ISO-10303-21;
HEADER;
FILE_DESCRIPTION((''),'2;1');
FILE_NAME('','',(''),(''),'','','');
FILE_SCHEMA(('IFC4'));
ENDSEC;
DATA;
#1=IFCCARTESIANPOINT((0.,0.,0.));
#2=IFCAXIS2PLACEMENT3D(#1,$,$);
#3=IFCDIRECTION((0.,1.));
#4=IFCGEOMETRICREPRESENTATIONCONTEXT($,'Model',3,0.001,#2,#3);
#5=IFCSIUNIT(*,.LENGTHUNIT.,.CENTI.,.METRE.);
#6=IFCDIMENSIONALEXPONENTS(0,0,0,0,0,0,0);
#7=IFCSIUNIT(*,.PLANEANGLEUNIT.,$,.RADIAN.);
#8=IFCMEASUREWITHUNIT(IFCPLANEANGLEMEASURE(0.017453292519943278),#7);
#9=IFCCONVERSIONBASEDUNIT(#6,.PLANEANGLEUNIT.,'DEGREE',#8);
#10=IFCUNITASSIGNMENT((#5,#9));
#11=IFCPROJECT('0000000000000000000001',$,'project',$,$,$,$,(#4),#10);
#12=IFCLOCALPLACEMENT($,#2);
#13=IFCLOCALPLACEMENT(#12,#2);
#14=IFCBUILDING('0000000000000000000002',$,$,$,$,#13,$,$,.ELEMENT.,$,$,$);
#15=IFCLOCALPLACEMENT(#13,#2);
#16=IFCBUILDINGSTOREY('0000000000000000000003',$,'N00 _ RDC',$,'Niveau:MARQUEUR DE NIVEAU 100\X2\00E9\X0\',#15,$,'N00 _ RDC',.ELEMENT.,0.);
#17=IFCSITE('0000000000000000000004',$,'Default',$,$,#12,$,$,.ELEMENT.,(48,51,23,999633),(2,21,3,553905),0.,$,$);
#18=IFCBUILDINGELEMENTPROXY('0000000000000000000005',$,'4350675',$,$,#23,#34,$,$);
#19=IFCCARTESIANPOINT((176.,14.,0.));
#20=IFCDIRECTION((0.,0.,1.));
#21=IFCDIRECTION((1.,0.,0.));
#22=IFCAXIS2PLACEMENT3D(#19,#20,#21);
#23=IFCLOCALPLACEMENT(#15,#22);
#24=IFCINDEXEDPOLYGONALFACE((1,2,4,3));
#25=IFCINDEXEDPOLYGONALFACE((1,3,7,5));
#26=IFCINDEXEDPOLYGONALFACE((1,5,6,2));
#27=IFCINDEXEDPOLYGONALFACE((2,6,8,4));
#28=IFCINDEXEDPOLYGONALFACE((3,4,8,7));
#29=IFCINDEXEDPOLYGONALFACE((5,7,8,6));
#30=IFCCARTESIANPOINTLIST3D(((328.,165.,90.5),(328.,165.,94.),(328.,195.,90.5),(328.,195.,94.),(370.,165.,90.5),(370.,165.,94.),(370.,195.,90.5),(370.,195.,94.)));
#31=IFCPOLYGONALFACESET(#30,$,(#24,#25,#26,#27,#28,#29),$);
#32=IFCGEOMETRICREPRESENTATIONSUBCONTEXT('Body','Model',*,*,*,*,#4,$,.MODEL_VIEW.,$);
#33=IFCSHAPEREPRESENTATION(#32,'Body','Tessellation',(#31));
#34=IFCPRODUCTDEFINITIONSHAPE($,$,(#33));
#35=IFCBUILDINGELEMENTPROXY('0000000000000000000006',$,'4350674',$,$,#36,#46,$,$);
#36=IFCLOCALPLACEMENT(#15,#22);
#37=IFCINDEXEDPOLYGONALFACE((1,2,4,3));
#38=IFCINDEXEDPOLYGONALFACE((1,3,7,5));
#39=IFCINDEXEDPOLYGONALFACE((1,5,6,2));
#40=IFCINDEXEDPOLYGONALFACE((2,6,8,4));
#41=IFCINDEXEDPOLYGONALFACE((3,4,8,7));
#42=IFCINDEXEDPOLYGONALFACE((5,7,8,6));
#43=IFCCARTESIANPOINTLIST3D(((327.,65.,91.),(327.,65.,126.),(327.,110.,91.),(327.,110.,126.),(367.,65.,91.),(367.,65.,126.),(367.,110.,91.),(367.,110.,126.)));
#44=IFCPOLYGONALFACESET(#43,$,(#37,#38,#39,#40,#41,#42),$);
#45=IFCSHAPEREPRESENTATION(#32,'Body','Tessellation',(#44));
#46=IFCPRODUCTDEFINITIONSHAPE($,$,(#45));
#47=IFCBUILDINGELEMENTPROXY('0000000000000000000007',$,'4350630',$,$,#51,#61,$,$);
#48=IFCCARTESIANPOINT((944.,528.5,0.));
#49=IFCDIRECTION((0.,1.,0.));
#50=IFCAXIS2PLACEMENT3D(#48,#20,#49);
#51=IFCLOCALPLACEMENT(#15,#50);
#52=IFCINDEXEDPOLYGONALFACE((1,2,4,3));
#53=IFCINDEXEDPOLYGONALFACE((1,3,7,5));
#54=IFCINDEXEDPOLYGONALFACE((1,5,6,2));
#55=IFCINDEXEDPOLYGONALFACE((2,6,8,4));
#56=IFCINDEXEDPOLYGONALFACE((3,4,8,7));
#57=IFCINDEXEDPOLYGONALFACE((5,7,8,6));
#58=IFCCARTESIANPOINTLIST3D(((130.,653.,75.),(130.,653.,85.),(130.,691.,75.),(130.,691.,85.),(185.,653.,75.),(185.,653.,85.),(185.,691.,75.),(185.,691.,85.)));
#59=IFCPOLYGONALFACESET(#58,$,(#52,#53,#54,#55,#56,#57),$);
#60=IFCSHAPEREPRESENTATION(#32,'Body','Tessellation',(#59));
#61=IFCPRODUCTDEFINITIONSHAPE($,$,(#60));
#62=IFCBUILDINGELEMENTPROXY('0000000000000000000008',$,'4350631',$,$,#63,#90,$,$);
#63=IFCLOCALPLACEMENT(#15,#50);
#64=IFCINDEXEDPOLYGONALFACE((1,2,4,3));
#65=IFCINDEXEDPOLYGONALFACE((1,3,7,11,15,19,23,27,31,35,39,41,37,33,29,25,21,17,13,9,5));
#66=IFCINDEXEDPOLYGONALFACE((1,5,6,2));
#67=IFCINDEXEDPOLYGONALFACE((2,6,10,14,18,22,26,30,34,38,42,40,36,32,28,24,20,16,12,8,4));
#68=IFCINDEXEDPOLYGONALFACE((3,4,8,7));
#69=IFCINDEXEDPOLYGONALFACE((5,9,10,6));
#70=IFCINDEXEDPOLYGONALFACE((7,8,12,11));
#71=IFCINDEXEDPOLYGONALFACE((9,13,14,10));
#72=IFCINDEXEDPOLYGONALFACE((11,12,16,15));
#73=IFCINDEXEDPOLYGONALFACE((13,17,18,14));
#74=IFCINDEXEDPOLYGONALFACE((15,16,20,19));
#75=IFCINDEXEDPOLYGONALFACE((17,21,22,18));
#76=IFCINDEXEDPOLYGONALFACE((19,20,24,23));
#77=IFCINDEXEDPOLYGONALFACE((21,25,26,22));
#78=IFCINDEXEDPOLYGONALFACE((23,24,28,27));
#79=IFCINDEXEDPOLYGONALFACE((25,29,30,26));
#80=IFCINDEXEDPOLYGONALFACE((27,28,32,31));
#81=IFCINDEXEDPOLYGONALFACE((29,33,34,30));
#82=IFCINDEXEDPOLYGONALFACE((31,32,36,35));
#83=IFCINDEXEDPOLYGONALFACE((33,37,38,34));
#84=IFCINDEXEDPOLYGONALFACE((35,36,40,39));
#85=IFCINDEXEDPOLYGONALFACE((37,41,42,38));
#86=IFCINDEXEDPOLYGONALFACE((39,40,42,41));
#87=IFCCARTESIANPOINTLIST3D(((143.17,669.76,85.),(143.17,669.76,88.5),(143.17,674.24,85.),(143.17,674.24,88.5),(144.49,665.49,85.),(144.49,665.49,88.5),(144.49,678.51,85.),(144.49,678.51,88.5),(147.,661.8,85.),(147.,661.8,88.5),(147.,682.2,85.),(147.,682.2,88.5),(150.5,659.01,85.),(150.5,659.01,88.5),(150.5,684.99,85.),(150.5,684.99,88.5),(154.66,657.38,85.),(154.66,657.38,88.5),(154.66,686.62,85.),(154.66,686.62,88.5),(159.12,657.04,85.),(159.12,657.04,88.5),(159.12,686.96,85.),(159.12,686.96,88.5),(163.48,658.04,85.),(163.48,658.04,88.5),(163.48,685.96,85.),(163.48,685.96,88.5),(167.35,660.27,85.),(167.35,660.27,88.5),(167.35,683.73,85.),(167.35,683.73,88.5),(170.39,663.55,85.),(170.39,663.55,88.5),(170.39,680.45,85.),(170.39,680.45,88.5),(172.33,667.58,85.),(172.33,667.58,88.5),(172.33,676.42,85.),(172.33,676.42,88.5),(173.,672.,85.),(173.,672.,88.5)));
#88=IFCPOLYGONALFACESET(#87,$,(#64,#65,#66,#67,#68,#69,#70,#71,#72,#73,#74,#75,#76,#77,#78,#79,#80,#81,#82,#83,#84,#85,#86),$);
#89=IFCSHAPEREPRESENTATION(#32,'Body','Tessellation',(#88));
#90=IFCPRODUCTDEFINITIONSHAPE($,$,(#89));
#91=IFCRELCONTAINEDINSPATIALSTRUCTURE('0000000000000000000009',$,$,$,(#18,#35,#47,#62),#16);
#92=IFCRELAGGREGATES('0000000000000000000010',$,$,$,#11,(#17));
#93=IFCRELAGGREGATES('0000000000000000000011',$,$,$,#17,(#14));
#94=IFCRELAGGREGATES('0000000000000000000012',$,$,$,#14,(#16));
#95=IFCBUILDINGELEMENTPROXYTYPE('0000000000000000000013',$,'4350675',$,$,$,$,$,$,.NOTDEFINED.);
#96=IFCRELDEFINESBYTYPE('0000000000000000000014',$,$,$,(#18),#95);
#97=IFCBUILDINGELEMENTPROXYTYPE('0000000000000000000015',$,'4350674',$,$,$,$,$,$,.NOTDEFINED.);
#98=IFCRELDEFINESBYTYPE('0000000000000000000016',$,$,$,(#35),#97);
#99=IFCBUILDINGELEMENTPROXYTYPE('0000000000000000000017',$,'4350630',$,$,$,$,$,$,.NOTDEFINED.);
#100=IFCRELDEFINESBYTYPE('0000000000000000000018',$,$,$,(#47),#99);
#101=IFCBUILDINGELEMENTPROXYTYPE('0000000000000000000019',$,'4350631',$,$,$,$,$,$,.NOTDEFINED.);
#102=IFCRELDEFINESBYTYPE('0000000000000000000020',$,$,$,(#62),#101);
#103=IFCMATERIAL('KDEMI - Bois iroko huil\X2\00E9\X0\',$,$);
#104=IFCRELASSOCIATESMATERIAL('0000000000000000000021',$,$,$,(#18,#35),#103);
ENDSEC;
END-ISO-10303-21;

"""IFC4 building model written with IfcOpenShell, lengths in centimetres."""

from ifc_helpers import new_model, entity, si_unit, converted_unit, direction, frame, origin, origin_2d_with_axis, place, context, subcontext, project, spatial, rectangle, circle, extrude, material, type_object, element, save


model = new_model("IFC4")

# Units and contexts
model_context = context("Model", 3, precision=0.001, world=origin(), true_north=direction((0.0, 1.0)))
body_context = subcontext(model_context, "Body", "Model", "MODEL_VIEW")
ifc_project = project(units=[si_unit("LENGTHUNIT", "METRE", prefix="CENTI"), converted_unit("PLANEANGLEUNIT", "DEGREE", entity("IfcPlaneAngleMeasure", 0.017453292519943278), si_unit("PLANEANGLEUNIT", "RADIAN"), dimensions=[0, 0, 0, 0, 0, 0, 0])], contexts=[model_context])

# Site, building, storey
site_placement = place(None, origin())
site = spatial("IfcSite", under=ifc_project, at=site_placement, Name="Default", CompositionType="ELEMENT", RefLatitude=(48, 51, 23, 999633), RefLongitude=(2, 21, 3, 553905), RefElevation=0.0)
building_placement = place(site_placement, origin())
building = spatial("IfcBuilding", under=site, at=building_placement, CompositionType="ELEMENT")
storey_placement = place(building_placement, origin())
storey = spatial("IfcBuildingStorey", under=building, at=storey_placement, Name="N00 _ RDC", ObjectType="Niveau:MARQUEUR DE NIVEAU 100é", LongName="N00 _ RDC", CompositionType="ELEMENT", Elevation=0.0)

# Shared definitions
ifc_material_1 = material(Name="KDEMI - Bois iroko huilé")

# Building element proxies
building_element_proxy_type_1 = type_object("IfcBuildingElementProxyType", Name="4350675", PredefinedType="NOTDEFINED")
proxy_1_placement = place(storey_placement, frame((176.0, 14.0, 0.0), z_axis=(0.0, 0.0, 1.0), x_axis=(1.0, 0.0, 0.0)))
element("IfcBuildingElementProxy", 1, at=proxy_1_placement, inside=storey, type_object=building_element_proxy_type_1, material=ifc_material_1, Name="4350675", context=body_context, shape_type="SweptSolid", body=[
    extrude(rectangle(XDim=42.0, YDim=30.0, at=origin_2d_with_axis()), frame((349.0, 180.0, 90.5)), (0.0, 0.0, 1.0), 3.5),
])
building_element_proxy_type_2 = type_object("IfcBuildingElementProxyType", Name="4350674", PredefinedType="NOTDEFINED")
proxy_2_placement = place(storey_placement, frame((176.0, 14.0, 0.0), z_axis=(0.0, 0.0, 1.0), x_axis=(1.0, 0.0, 0.0)))
element("IfcBuildingElementProxy", 2, at=proxy_2_placement, inside=storey, type_object=building_element_proxy_type_2, material=ifc_material_1, Name="4350674", context=body_context, shape_type="SweptSolid", body=[
    extrude(rectangle(XDim=40.0, YDim=45.0, at=origin_2d_with_axis()), frame((347.0, 87.5, 91.0)), (0.0, 0.0, 1.0), 35.0),
])
building_element_proxy_type_3 = type_object("IfcBuildingElementProxyType", Name="4350630", PredefinedType="NOTDEFINED")
proxy_3_placement = place(storey_placement, frame((944.0, 528.5, 0.0), z_axis=(0.0, 0.0, 1.0), x_axis=(0.0, 1.0, 0.0)))
element("IfcBuildingElementProxy", 3, at=proxy_3_placement, inside=storey, type_object=building_element_proxy_type_3, Name="4350630", context=body_context, shape_type="SweptSolid", body=[
    extrude(rectangle(XDim=55.0, YDim=38.0, at=origin_2d_with_axis()), frame((157.5, 672.0, 75.0)), (0.0, 0.0, 1.0), 10.0),
])
building_element_proxy_type_4 = type_object("IfcBuildingElementProxyType", Name="4350631", PredefinedType="NOTDEFINED")
proxy_4_placement = place(storey_placement, frame((944.0, 528.5, 0.0), z_axis=(0.0, 0.0, 1.0), x_axis=(0.0, 1.0, 0.0)))
element("IfcBuildingElementProxy", 4, at=proxy_4_placement, inside=storey, type_object=building_element_proxy_type_4, Name="4350631", context=body_context, shape_type="SweptSolid", body=[
    extrude(circle(Radius=15.0, at=origin_2d_with_axis()), frame((158.0, 672.0, 85.0)), (0.0, 0.0, 1.0), 3.5),
])

save(model, "model.ifc")
